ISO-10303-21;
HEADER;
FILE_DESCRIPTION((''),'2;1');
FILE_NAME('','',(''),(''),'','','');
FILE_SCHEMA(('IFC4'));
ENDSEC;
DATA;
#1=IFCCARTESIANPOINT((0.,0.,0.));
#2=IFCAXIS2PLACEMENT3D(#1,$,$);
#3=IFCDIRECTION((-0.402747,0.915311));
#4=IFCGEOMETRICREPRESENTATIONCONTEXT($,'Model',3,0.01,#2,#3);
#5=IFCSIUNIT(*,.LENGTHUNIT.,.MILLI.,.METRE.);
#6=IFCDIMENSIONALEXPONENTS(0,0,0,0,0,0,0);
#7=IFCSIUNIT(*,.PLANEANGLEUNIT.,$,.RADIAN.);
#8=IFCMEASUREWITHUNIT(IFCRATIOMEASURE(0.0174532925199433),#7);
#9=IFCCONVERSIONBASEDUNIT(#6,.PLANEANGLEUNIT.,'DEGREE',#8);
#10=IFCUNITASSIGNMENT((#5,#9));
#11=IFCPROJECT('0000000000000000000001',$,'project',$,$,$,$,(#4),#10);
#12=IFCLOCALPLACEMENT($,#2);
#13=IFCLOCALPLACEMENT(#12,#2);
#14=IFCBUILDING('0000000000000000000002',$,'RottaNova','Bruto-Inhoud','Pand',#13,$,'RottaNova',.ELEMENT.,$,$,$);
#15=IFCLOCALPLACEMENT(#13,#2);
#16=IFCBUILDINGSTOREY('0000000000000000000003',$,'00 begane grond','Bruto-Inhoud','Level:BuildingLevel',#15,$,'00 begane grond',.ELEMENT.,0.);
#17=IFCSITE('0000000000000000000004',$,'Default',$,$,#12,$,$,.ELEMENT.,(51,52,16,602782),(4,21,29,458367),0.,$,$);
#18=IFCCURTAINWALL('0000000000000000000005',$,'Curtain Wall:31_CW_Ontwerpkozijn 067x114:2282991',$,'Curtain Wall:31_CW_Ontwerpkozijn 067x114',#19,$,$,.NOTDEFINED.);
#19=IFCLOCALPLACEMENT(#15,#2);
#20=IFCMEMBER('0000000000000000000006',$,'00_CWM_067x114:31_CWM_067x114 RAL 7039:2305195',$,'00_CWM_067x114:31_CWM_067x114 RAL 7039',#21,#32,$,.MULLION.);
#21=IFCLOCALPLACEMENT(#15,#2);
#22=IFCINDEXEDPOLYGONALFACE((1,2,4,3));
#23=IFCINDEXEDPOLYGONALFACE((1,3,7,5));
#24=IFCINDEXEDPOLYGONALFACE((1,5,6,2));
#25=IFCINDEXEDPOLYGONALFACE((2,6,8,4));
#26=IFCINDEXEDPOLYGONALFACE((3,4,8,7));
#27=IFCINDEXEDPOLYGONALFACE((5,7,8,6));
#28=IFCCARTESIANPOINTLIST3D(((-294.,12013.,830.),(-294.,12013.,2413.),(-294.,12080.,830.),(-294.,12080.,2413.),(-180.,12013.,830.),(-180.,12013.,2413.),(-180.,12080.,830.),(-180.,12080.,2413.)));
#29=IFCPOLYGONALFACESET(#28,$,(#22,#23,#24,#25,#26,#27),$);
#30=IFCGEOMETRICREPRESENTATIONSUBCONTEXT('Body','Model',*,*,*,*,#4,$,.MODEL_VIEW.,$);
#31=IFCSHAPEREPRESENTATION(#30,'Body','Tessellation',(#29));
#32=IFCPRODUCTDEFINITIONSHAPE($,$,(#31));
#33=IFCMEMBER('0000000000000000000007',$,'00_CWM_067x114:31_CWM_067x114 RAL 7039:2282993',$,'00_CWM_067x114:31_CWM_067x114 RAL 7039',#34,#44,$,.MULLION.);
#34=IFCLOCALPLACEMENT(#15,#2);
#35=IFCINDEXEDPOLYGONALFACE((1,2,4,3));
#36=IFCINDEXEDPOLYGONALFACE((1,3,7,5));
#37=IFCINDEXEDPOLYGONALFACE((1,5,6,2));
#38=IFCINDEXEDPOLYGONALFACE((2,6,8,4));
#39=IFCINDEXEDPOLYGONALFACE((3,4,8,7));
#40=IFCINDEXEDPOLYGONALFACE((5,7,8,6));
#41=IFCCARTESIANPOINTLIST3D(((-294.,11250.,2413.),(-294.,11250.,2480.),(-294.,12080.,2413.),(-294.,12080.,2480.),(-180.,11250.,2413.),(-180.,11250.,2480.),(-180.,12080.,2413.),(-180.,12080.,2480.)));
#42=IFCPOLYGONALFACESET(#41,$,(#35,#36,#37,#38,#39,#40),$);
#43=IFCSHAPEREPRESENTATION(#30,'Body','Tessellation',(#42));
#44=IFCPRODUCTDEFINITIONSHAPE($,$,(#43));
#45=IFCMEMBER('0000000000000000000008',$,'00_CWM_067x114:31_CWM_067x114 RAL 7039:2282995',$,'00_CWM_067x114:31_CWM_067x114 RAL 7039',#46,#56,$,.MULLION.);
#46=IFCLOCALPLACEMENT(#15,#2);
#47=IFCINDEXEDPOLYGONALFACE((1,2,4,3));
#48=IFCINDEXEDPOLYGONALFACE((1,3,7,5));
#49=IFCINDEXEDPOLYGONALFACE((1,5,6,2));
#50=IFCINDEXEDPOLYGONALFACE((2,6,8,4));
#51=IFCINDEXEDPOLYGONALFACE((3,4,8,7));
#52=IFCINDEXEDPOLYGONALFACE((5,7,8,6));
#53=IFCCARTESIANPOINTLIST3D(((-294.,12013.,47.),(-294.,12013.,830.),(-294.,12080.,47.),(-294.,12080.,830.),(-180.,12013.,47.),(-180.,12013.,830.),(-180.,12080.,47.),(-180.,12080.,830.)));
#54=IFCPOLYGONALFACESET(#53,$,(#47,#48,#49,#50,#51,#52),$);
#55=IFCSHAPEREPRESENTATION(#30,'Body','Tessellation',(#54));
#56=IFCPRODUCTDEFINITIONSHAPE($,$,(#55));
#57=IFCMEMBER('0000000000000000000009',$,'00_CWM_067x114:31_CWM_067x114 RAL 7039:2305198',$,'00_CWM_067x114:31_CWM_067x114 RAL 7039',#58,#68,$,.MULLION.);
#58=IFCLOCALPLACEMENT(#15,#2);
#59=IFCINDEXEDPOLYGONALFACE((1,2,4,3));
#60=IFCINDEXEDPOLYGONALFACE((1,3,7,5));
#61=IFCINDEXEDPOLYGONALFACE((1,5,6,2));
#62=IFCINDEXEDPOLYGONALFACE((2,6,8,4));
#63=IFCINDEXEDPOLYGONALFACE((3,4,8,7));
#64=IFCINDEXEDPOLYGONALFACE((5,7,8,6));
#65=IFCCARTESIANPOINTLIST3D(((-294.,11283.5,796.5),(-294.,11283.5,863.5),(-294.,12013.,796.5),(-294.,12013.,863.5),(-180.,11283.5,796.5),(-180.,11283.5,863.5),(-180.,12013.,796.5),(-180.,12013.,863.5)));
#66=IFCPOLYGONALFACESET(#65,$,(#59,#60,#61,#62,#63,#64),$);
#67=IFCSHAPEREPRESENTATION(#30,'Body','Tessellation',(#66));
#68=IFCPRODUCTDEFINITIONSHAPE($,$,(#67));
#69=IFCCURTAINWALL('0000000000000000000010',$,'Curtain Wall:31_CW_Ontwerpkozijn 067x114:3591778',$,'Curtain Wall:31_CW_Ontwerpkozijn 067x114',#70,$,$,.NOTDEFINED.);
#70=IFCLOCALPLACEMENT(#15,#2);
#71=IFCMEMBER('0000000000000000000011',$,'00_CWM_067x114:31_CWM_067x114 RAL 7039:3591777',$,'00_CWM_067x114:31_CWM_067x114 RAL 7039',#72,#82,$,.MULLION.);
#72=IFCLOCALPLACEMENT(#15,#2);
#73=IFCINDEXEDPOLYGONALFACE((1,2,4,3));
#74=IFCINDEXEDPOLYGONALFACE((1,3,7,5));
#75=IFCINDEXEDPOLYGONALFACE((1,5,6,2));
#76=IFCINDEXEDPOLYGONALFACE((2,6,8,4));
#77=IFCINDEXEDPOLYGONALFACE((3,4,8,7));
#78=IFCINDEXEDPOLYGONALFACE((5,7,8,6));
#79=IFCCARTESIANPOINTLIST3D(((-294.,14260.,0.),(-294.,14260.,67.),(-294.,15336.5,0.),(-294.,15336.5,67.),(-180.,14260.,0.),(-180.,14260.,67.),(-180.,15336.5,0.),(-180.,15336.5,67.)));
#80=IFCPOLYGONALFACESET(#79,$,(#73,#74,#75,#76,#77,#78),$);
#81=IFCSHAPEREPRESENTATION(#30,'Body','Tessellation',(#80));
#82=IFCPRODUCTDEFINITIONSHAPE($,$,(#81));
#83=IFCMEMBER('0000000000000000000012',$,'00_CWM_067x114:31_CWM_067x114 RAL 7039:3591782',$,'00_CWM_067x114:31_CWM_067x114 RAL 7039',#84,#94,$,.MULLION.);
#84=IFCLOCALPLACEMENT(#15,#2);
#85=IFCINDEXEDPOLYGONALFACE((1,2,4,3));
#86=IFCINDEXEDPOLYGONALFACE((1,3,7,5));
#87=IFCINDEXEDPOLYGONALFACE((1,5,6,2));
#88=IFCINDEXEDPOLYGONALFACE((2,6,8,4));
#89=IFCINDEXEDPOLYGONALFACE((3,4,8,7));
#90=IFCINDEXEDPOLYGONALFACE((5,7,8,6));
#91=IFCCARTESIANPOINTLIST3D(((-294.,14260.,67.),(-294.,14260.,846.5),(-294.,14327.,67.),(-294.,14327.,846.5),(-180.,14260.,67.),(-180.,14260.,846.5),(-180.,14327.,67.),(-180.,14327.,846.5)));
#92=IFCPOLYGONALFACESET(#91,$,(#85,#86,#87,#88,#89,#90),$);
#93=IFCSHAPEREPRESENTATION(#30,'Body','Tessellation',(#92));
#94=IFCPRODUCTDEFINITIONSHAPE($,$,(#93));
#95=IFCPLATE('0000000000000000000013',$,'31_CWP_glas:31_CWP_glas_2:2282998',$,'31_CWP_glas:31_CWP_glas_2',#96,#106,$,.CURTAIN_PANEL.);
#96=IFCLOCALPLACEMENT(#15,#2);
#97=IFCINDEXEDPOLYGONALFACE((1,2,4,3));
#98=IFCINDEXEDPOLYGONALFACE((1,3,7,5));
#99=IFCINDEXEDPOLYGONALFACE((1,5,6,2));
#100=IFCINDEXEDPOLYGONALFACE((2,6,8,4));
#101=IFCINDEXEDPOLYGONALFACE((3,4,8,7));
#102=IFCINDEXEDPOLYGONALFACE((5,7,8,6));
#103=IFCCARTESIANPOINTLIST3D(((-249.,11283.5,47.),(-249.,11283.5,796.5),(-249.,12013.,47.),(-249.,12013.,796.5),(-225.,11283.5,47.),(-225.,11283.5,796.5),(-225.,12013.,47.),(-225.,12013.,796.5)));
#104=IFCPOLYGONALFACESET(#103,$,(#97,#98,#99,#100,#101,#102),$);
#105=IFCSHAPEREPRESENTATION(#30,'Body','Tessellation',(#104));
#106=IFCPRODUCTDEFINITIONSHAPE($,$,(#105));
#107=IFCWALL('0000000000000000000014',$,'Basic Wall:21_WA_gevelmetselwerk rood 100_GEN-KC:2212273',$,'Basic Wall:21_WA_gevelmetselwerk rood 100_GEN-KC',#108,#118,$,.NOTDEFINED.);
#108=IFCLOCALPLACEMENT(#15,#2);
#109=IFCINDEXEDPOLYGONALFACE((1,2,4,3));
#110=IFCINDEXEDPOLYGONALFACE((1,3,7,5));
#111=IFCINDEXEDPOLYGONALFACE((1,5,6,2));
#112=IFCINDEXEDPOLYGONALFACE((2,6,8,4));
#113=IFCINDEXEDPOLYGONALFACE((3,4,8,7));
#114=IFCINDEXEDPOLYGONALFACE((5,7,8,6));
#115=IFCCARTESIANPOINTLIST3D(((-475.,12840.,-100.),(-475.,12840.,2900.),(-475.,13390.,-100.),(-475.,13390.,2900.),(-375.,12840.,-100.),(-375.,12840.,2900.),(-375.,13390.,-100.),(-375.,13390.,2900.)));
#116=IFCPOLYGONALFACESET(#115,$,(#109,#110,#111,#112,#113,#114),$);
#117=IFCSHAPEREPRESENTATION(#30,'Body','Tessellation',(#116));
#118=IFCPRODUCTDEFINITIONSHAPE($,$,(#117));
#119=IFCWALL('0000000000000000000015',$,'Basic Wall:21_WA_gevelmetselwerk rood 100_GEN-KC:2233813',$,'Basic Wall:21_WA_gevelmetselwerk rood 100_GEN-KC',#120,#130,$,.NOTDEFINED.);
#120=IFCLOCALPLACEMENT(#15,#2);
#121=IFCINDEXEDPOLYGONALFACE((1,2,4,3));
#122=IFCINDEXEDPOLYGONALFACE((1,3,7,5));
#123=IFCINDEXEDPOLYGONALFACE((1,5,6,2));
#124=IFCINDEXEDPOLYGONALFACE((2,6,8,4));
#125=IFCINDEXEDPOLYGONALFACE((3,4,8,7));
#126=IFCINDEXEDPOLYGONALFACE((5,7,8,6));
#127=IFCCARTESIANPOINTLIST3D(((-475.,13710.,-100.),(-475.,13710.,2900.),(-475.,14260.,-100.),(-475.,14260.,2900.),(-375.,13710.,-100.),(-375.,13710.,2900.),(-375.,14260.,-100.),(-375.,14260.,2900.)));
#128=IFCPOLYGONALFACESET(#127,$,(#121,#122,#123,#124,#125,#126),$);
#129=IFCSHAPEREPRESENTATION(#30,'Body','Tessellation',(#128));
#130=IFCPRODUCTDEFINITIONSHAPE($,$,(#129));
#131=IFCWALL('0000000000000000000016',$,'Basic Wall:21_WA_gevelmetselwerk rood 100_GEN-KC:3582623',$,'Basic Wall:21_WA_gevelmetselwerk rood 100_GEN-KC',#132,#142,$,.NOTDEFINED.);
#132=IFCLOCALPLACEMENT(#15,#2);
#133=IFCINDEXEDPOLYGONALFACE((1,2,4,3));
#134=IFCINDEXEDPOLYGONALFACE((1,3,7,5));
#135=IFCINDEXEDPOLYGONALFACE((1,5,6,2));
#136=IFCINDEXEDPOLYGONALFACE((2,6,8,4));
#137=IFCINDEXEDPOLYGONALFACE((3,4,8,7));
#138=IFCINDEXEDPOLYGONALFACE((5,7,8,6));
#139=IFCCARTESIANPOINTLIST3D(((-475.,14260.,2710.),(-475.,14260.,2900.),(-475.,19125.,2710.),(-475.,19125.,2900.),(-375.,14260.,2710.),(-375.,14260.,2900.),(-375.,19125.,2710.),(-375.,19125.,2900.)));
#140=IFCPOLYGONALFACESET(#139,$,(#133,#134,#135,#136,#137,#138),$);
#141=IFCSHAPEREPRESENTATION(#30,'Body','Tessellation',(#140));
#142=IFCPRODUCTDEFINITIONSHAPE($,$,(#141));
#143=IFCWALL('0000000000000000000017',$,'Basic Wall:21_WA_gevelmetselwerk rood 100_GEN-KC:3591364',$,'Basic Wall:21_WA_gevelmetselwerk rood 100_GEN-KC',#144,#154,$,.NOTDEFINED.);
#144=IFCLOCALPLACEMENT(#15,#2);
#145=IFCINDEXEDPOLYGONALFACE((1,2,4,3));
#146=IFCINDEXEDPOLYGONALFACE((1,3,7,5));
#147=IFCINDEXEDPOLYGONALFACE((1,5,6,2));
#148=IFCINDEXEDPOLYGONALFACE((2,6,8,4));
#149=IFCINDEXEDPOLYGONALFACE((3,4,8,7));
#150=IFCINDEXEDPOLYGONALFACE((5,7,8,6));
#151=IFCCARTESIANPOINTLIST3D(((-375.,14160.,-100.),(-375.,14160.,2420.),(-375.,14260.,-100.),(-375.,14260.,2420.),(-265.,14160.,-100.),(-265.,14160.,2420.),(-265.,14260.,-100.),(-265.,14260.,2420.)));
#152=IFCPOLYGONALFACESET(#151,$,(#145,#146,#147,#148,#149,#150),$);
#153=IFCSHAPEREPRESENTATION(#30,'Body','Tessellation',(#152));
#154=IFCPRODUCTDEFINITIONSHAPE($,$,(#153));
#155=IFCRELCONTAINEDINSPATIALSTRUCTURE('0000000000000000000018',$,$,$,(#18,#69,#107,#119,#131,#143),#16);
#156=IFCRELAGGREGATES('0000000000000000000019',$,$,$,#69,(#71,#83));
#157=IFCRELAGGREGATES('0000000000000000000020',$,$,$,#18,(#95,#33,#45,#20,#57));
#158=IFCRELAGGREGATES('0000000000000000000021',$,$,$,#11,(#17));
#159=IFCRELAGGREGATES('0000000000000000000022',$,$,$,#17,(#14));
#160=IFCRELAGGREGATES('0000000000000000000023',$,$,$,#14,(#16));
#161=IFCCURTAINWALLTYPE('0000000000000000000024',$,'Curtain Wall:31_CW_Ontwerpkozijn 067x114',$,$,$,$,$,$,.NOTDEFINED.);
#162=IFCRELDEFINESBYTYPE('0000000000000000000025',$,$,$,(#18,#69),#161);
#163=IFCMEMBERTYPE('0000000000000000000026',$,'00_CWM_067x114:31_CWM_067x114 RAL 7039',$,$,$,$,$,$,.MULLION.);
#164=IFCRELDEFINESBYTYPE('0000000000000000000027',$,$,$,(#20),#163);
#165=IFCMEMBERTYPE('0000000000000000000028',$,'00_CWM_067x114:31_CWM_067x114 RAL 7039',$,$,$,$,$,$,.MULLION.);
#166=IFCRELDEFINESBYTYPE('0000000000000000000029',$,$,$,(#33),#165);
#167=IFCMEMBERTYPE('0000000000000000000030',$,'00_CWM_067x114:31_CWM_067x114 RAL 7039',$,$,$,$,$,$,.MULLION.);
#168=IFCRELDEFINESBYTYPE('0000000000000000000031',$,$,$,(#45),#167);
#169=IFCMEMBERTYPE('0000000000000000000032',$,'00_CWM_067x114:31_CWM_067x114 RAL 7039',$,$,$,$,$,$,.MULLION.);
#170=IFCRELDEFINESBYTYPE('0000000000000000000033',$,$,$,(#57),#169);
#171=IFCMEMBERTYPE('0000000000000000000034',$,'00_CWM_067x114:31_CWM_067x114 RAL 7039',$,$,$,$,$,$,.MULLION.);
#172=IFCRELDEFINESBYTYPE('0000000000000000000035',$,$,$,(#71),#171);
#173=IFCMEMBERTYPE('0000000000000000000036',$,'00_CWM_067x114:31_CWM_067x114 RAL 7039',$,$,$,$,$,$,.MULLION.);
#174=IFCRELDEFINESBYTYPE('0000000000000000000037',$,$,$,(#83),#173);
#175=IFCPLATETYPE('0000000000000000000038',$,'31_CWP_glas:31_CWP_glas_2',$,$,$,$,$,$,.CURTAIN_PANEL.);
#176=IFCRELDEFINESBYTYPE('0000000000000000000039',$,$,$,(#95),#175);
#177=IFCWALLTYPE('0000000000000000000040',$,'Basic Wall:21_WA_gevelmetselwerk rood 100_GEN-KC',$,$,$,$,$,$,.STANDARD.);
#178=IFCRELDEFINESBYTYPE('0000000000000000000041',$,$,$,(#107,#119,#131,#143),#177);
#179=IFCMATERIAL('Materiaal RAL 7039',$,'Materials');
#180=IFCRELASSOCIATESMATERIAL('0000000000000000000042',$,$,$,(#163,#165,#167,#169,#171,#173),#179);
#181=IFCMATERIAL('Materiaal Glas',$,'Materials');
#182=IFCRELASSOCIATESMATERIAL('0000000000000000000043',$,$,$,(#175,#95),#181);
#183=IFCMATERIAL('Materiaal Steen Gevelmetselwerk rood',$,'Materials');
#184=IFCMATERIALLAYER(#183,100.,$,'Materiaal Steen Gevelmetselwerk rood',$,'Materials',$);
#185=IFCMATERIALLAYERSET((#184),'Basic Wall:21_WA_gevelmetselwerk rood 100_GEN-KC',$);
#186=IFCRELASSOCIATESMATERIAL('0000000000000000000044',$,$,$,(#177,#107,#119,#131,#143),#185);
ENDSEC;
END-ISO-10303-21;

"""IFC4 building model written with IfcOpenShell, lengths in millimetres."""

from ifc_helpers import new_model, entity, si_unit, converted_unit, direction, frame, frame_2d, origin, origin_2d_with_axis, place, context, subcontext, project, spatial, rectangle, extrude, source, transform, mapped, material, layer, layer_set, material_profile, profile_set, type_object, type_shapes, element, aggregate, save


model = new_model("IFC4")

# Units and contexts
model_context = context("Model", 3, precision=0.01, world=origin(), true_north=direction((-0.402747, 0.915311)))
body_context = subcontext(model_context, "Body", "Model", "MODEL_VIEW")
ifc_project = project(units=[si_unit("LENGTHUNIT", "METRE", prefix="MILLI"), converted_unit("PLANEANGLEUNIT", "DEGREE", entity("IfcRatioMeasure", 0.0174532925199433), si_unit("PLANEANGLEUNIT", "RADIAN"), dimensions=[0, 0, 0, 0, 0, 0, 0])], contexts=[model_context])

# Site, building, storey
site_placement = place(None, origin())
site = spatial("IfcSite", under=ifc_project, at=site_placement, Name="Default", CompositionType="ELEMENT", RefLatitude=(51, 52, 16, 602782), RefLongitude=(4, 21, 29, 458367), RefElevation=0.0)
building_placement = place(site_placement, origin())
building = spatial("IfcBuilding", under=site, at=building_placement, Name="RottaNova", Description="Bruto-Inhoud", ObjectType="Pand", LongName="RottaNova", CompositionType="ELEMENT")
storey_placement = place(building_placement, origin())
storey = spatial("IfcBuildingStorey", under=building, at=storey_placement, Name="00 begane grond", Description="Bruto-Inhoud", ObjectType="Level:BuildingLevel", LongName="00 begane grond", CompositionType="ELEMENT", Elevation=0.0)

# Curtain walls, members
curtain_wall_type = type_object("IfcCurtainWallType", Name="Curtain Wall:31_CW_Ontwerpkozijn 067x114", PredefinedType="NOTDEFINED")
curtain_wall_1_placement = place(storey_placement, origin())
curtain_wall_1 = element("IfcCurtainWall", 1, at=curtain_wall_1_placement, inside=storey, type_object=curtain_wall_type, Name="Curtain Wall:31_CW_Ontwerpkozijn 067x114:2282991", ObjectType="Curtain Wall:31_CW_Ontwerpkozijn 067x114", PredefinedType="NOTDEFINED")
ifc_material_1 = material(Name="Materiaal RAL 7039", Category="Materials")
ifc_material_profile = material_profile(ifc_material_1, rectangle(XDim=114.0, YDim=67.0, at=origin_2d_with_axis()), Name="31_CWM_067x114 RAL 7039")
ifc_profile_set = profile_set([ifc_material_profile], Name="31_CWM_067x114 RAL 7039")
member_type_1 = type_object("IfcMemberType", Name="00_CWM_067x114:31_CWM_067x114 RAL 7039", PredefinedType="MULLION", material=ifc_profile_set)
shared_shape_1 = source(origin(), body_context, "Body", "SweptSolid", [
    extrude(rectangle(XDim=114.0, YDim=67.0, at=frame_2d((0.0, 0.0), x_axis=(1.0, 0.0))), frame((-33.5, -57.0, -1583.0), z_axis=(0.0, 0.0, 1.0), x_axis=(0.0, -1.0, 0.0)), (0.0, 0.0, 1.0), 1583.0),
])
type_shapes(member_type_1, [shared_shape_1])
member_1_placement = place(curtain_wall_1_placement, frame((-180.0, 12080.0, 830.0), z_axis=(0.0, 0.0, -1.0), x_axis=(0.0, 1.0, 0.0)))
member_1 = element("IfcMember", 2, at=member_1_placement, type_object=member_type_1, Name="00_CWM_067x114:31_CWM_067x114 RAL 7039:2305195", ObjectType="00_CWM_067x114:31_CWM_067x114 RAL 7039", PredefinedType="MULLION", context=body_context, shape_type="MappedRepresentation", body=[
    mapped(shared_shape_1, transform((0.0, 0.0, 0.0), scale=1.0)),
])
member_type_2 = type_object("IfcMemberType", Name="00_CWM_067x114:31_CWM_067x114 RAL 7039", PredefinedType="MULLION", material=ifc_profile_set)
shared_shape_2 = source(origin(), body_context, "Body", "SweptSolid", [
    extrude(rectangle(XDim=114.0, YDim=67.0, at=frame_2d((0.0, 0.0), x_axis=(1.0, 0.0))), frame((-33.5, -57.0, -830.0), z_axis=(0.0, 0.0, 1.0), x_axis=(0.0, -1.0, 0.0)), (0.0, 0.0, 1.0), 830.0),
])
type_shapes(member_type_2, [shared_shape_2])
member_2_placement = place(curtain_wall_1_placement, frame((-180.0, 12080.0, 2480.0), z_axis=(0.0, 1.0, 0.0), x_axis=(0.0, 0.0, 1.0)))
member_2 = element("IfcMember", 3, at=member_2_placement, type_object=member_type_2, Name="00_CWM_067x114:31_CWM_067x114 RAL 7039:2282993", ObjectType="00_CWM_067x114:31_CWM_067x114 RAL 7039", PredefinedType="MULLION", context=body_context, shape_type="MappedRepresentation", body=[
    mapped(shared_shape_2, transform((0.0, 0.0, 0.0), scale=1.0)),
])
member_type_3 = type_object("IfcMemberType", Name="00_CWM_067x114:31_CWM_067x114 RAL 7039", PredefinedType="MULLION", material=ifc_profile_set)
shared_shape_3 = source(origin(), body_context, "Body", "SweptSolid", [
    extrude(rectangle(XDim=114.0, YDim=67.0, at=frame_2d((0.0, 0.0), x_axis=(1.0, 0.0))), frame((-33.5, -57.0, -783.0), z_axis=(0.0, 0.0, 1.0), x_axis=(0.0, -1.0, 0.0)), (0.0, 0.0, 1.0), 783.0),
])
type_shapes(member_type_3, [shared_shape_3])
member_3_placement = place(curtain_wall_1_placement, frame((-180.0, 12080.0, 47.0), z_axis=(0.0, 0.0, -1.0), x_axis=(0.0, 1.0, 0.0)))
member_3 = element("IfcMember", 4, at=member_3_placement, type_object=member_type_3, Name="00_CWM_067x114:31_CWM_067x114 RAL 7039:2282995", ObjectType="00_CWM_067x114:31_CWM_067x114 RAL 7039", PredefinedType="MULLION", context=body_context, shape_type="MappedRepresentation", body=[
    mapped(shared_shape_3, transform((0.0, 0.0, 0.0), scale=1.0)),
])
member_type_4 = type_object("IfcMemberType", Name="00_CWM_067x114:31_CWM_067x114 RAL 7039", PredefinedType="MULLION", material=ifc_profile_set)
shared_shape_4 = source(origin(), body_context, "Body", "SweptSolid", [
    extrude(rectangle(XDim=114.0, YDim=67.0, at=origin_2d_with_axis()), frame((0.0, -57.0, -729.5), z_axis=(0.0, 0.0, 1.0), x_axis=(0.0, -1.0, 0.0)), (0.0, 0.0, 1.0), 729.5),
])
type_shapes(member_type_4, [shared_shape_4])
member_4_placement = place(curtain_wall_1_placement, frame((-180.0, 12013.0, 830.0), z_axis=(0.0, 1.0, 0.0), x_axis=(0.0, 0.0, 1.0)))
member_4 = element("IfcMember", 5, at=member_4_placement, type_object=member_type_4, Name="00_CWM_067x114:31_CWM_067x114 RAL 7039:2305198", ObjectType="00_CWM_067x114:31_CWM_067x114 RAL 7039", PredefinedType="MULLION", context=body_context, shape_type="MappedRepresentation", body=[
    mapped(shared_shape_4, transform((0.0, 0.0, 0.0), scale=1.0)),
])
curtain_wall_2_placement = place(storey_placement, origin())
curtain_wall_2 = element("IfcCurtainWall", 6, at=curtain_wall_2_placement, inside=storey, type_object=curtain_wall_type, Name="Curtain Wall:31_CW_Ontwerpkozijn 067x114:3591778", ObjectType="Curtain Wall:31_CW_Ontwerpkozijn 067x114", PredefinedType="NOTDEFINED")
member_type_5 = type_object("IfcMemberType", Name="00_CWM_067x114:31_CWM_067x114 RAL 7039", PredefinedType="MULLION", material=ifc_profile_set)
shared_shape_5 = source(origin(), body_context, "Body", "SweptSolid", [
    extrude(rectangle(XDim=114.0, YDim=67.0, at=frame_2d((0.0, 0.0), x_axis=(1.0, 0.0))), frame((-33.5, -57.0, -1076.5), z_axis=(0.0, 0.0, 1.0), x_axis=(0.0, -1.0, 0.0)), (0.0, 0.0, 1.0), 1076.5),
])
type_shapes(member_type_5, [shared_shape_5])
member_5_placement = place(curtain_wall_2_placement, frame((-180.0, 14260.0, 0.0), z_axis=(0.0, -1.0, 0.0), x_axis=(0.0, 0.0, -1.0)))
member_5 = element("IfcMember", 7, at=member_5_placement, type_object=member_type_5, Name="00_CWM_067x114:31_CWM_067x114 RAL 7039:3591777", ObjectType="00_CWM_067x114:31_CWM_067x114 RAL 7039", PredefinedType="MULLION", context=body_context, shape_type="MappedRepresentation", body=[
    mapped(shared_shape_5, transform((0.0, 0.0, 0.0), scale=1.0)),
])
member_type_6 = type_object("IfcMemberType", Name="00_CWM_067x114:31_CWM_067x114 RAL 7039", PredefinedType="MULLION", material=ifc_profile_set)
shared_shape_6 = source(origin(), body_context, "Body", "SweptSolid", [
    extrude(rectangle(XDim=114.0, YDim=67.0, at=frame_2d((0.0, 0.0), x_axis=(1.0, 0.0))), frame((-33.5, -57.0, -779.5), z_axis=(0.0, 0.0, 1.0), x_axis=(0.0, -1.0, 0.0)), (0.0, 0.0, 1.0), 779.5),
])
type_shapes(member_type_6, [shared_shape_6])
member_6_placement = place(curtain_wall_2_placement, frame((-180.0, 14260.0, 846.5), z_axis=(0.0, 0.0, 1.0), x_axis=(0.0, -1.0, 0.0)))
member_6 = element("IfcMember", 8, at=member_6_placement, type_object=member_type_6, Name="00_CWM_067x114:31_CWM_067x114 RAL 7039:3591782", ObjectType="00_CWM_067x114:31_CWM_067x114 RAL 7039", PredefinedType="MULLION", context=body_context, shape_type="MappedRepresentation", body=[
    mapped(shared_shape_6, transform((0.0, 0.0, 0.0), scale=1.0)),
])
aggregate(curtain_wall_2, [member_5, member_6])

# Plate
ifc_material_2 = material(Name="Materiaal Glas", Category="Materials")
plate_type = type_object("IfcPlateType", Name="31_CWP_glas:31_CWP_glas_2", PredefinedType="CURTAIN_PANEL", material=ifc_material_2)
shared_shape_7 = source(origin(), body_context, "Body", "SweptSolid", [
    extrude(rectangle(XDim=24.0, YDim=729.5, at=frame_2d((0.0, 0.0), x_axis=(1.0, 0.0))), frame((364.8, 12.0, 0.0), z_axis=(0.0, 0.0, 1.0), x_axis=(0.0, 1.0, 0.0)), (0.0, 0.0, 1.0), 749.5),
])
type_shapes(plate_type, [shared_shape_7])
plate_placement = place(curtain_wall_1_placement, frame((-225.0, 11283.5, 47.0), z_axis=(0.0, 0.0, 1.0), x_axis=(0.0, 1.0, 0.0)))
plate = element("IfcPlate", 9, at=plate_placement, type_object=plate_type, material=ifc_material_2, Name="31_CWP_glas:31_CWP_glas_2:2282998", ObjectType="31_CWP_glas:31_CWP_glas_2", PredefinedType="CURTAIN_PANEL", context=body_context, shape_type="MappedRepresentation", body=[
    mapped(shared_shape_7, transform((0.0, 0.0, 0.0), scale=1.0)),
])

# Walls
ifc_material_3 = material(Name="Materiaal Steen Gevelmetselwerk rood", Category="Materials")
ifc_layer_1 = layer(ifc_material_3, 100.0, Name="Materiaal Steen Gevelmetselwerk rood", Category="Materials")
ifc_layer_set_1 = layer_set([ifc_layer_1], Name="Basic Wall:21_WA_gevelmetselwerk rood 100_GEN-KC")
wall_type_1 = type_object("IfcWallType", Name="Basic Wall:21_WA_gevelmetselwerk rood 100_GEN-KC", PredefinedType="STANDARD", material=ifc_layer_set_1)
wall_1_placement = place(storey_placement, frame((-425.0, 12840.0, -100.0), z_axis=(0.0, 0.0, 1.0), x_axis=(0.0, 1.0, 0.0)))
element("IfcWall", 10, at=wall_1_placement, inside=storey, type_object=wall_type_1, material=ifc_layer_set_1, Name="Basic Wall:21_WA_gevelmetselwerk rood 100_GEN-KC:2212273", ObjectType="Basic Wall:21_WA_gevelmetselwerk rood 100_GEN-KC", PredefinedType="NOTDEFINED", context=body_context, shape_type="SweptSolid", body=[
    extrude(rectangle(XDim=550.0, YDim=100.0, at=frame_2d((275.0, 0.0), x_axis=(-1.0, 0.0))), origin(), (0.0, 0.0, 1.0), 3000.0),
])
wall_2_placement = place(storey_placement, frame((-425.0, 13710.0, -100.0), z_axis=(0.0, 0.0, 1.0), x_axis=(0.0, 1.0, 0.0)))
element("IfcWall", 11, at=wall_2_placement, inside=storey, type_object=wall_type_1, material=ifc_layer_set_1, Name="Basic Wall:21_WA_gevelmetselwerk rood 100_GEN-KC:2233813", ObjectType="Basic Wall:21_WA_gevelmetselwerk rood 100_GEN-KC", PredefinedType="NOTDEFINED", context=body_context, shape_type="SweptSolid", body=[
    extrude(rectangle(XDim=550.0, YDim=100.0, at=frame_2d((275.0, 0.0), x_axis=(-1.0, 0.0))), origin(), (0.0, 0.0, 1.0), 3000.0),
])
wall_3_placement = place(storey_placement, frame((-425.0, 14260.0, 2710.0), z_axis=(0.0, 0.0, 1.0), x_axis=(0.0, 1.0, 0.0)))
element("IfcWall", 12, at=wall_3_placement, inside=storey, type_object=wall_type_1, material=ifc_layer_set_1, Name="Basic Wall:21_WA_gevelmetselwerk rood 100_GEN-KC:3582623", ObjectType="Basic Wall:21_WA_gevelmetselwerk rood 100_GEN-KC", PredefinedType="NOTDEFINED", context=body_context, shape_type="SweptSolid", body=[
    extrude(rectangle(XDim=4865.0, YDim=100.0, at=frame_2d((2432.5, 0.0), x_axis=(-1.0, 0.0))), origin(), (0.0, 0.0, 1.0), 190.0),
])
wall_4_placement = place(storey_placement, frame((-375.0, 14210.0, -100.0)))
element("IfcWall", 13, at=wall_4_placement, inside=storey, type_object=wall_type_1, material=ifc_layer_set_1, Name="Basic Wall:21_WA_gevelmetselwerk rood 100_GEN-KC:3591364", ObjectType="Basic Wall:21_WA_gevelmetselwerk rood 100_GEN-KC", PredefinedType="NOTDEFINED", context=body_context, shape_type="SweptSolid", body=[
    extrude(rectangle(XDim=110.0, YDim=100.0, at=frame_2d((55.0, 0.0), x_axis=(-1.0, 0.0))), origin(), (0.0, 0.0, 1.0), 2520.0),
])

aggregate(curtain_wall_1, [plate, member_2, member_3, member_1, member_4])

save(model, "model.ifc")
